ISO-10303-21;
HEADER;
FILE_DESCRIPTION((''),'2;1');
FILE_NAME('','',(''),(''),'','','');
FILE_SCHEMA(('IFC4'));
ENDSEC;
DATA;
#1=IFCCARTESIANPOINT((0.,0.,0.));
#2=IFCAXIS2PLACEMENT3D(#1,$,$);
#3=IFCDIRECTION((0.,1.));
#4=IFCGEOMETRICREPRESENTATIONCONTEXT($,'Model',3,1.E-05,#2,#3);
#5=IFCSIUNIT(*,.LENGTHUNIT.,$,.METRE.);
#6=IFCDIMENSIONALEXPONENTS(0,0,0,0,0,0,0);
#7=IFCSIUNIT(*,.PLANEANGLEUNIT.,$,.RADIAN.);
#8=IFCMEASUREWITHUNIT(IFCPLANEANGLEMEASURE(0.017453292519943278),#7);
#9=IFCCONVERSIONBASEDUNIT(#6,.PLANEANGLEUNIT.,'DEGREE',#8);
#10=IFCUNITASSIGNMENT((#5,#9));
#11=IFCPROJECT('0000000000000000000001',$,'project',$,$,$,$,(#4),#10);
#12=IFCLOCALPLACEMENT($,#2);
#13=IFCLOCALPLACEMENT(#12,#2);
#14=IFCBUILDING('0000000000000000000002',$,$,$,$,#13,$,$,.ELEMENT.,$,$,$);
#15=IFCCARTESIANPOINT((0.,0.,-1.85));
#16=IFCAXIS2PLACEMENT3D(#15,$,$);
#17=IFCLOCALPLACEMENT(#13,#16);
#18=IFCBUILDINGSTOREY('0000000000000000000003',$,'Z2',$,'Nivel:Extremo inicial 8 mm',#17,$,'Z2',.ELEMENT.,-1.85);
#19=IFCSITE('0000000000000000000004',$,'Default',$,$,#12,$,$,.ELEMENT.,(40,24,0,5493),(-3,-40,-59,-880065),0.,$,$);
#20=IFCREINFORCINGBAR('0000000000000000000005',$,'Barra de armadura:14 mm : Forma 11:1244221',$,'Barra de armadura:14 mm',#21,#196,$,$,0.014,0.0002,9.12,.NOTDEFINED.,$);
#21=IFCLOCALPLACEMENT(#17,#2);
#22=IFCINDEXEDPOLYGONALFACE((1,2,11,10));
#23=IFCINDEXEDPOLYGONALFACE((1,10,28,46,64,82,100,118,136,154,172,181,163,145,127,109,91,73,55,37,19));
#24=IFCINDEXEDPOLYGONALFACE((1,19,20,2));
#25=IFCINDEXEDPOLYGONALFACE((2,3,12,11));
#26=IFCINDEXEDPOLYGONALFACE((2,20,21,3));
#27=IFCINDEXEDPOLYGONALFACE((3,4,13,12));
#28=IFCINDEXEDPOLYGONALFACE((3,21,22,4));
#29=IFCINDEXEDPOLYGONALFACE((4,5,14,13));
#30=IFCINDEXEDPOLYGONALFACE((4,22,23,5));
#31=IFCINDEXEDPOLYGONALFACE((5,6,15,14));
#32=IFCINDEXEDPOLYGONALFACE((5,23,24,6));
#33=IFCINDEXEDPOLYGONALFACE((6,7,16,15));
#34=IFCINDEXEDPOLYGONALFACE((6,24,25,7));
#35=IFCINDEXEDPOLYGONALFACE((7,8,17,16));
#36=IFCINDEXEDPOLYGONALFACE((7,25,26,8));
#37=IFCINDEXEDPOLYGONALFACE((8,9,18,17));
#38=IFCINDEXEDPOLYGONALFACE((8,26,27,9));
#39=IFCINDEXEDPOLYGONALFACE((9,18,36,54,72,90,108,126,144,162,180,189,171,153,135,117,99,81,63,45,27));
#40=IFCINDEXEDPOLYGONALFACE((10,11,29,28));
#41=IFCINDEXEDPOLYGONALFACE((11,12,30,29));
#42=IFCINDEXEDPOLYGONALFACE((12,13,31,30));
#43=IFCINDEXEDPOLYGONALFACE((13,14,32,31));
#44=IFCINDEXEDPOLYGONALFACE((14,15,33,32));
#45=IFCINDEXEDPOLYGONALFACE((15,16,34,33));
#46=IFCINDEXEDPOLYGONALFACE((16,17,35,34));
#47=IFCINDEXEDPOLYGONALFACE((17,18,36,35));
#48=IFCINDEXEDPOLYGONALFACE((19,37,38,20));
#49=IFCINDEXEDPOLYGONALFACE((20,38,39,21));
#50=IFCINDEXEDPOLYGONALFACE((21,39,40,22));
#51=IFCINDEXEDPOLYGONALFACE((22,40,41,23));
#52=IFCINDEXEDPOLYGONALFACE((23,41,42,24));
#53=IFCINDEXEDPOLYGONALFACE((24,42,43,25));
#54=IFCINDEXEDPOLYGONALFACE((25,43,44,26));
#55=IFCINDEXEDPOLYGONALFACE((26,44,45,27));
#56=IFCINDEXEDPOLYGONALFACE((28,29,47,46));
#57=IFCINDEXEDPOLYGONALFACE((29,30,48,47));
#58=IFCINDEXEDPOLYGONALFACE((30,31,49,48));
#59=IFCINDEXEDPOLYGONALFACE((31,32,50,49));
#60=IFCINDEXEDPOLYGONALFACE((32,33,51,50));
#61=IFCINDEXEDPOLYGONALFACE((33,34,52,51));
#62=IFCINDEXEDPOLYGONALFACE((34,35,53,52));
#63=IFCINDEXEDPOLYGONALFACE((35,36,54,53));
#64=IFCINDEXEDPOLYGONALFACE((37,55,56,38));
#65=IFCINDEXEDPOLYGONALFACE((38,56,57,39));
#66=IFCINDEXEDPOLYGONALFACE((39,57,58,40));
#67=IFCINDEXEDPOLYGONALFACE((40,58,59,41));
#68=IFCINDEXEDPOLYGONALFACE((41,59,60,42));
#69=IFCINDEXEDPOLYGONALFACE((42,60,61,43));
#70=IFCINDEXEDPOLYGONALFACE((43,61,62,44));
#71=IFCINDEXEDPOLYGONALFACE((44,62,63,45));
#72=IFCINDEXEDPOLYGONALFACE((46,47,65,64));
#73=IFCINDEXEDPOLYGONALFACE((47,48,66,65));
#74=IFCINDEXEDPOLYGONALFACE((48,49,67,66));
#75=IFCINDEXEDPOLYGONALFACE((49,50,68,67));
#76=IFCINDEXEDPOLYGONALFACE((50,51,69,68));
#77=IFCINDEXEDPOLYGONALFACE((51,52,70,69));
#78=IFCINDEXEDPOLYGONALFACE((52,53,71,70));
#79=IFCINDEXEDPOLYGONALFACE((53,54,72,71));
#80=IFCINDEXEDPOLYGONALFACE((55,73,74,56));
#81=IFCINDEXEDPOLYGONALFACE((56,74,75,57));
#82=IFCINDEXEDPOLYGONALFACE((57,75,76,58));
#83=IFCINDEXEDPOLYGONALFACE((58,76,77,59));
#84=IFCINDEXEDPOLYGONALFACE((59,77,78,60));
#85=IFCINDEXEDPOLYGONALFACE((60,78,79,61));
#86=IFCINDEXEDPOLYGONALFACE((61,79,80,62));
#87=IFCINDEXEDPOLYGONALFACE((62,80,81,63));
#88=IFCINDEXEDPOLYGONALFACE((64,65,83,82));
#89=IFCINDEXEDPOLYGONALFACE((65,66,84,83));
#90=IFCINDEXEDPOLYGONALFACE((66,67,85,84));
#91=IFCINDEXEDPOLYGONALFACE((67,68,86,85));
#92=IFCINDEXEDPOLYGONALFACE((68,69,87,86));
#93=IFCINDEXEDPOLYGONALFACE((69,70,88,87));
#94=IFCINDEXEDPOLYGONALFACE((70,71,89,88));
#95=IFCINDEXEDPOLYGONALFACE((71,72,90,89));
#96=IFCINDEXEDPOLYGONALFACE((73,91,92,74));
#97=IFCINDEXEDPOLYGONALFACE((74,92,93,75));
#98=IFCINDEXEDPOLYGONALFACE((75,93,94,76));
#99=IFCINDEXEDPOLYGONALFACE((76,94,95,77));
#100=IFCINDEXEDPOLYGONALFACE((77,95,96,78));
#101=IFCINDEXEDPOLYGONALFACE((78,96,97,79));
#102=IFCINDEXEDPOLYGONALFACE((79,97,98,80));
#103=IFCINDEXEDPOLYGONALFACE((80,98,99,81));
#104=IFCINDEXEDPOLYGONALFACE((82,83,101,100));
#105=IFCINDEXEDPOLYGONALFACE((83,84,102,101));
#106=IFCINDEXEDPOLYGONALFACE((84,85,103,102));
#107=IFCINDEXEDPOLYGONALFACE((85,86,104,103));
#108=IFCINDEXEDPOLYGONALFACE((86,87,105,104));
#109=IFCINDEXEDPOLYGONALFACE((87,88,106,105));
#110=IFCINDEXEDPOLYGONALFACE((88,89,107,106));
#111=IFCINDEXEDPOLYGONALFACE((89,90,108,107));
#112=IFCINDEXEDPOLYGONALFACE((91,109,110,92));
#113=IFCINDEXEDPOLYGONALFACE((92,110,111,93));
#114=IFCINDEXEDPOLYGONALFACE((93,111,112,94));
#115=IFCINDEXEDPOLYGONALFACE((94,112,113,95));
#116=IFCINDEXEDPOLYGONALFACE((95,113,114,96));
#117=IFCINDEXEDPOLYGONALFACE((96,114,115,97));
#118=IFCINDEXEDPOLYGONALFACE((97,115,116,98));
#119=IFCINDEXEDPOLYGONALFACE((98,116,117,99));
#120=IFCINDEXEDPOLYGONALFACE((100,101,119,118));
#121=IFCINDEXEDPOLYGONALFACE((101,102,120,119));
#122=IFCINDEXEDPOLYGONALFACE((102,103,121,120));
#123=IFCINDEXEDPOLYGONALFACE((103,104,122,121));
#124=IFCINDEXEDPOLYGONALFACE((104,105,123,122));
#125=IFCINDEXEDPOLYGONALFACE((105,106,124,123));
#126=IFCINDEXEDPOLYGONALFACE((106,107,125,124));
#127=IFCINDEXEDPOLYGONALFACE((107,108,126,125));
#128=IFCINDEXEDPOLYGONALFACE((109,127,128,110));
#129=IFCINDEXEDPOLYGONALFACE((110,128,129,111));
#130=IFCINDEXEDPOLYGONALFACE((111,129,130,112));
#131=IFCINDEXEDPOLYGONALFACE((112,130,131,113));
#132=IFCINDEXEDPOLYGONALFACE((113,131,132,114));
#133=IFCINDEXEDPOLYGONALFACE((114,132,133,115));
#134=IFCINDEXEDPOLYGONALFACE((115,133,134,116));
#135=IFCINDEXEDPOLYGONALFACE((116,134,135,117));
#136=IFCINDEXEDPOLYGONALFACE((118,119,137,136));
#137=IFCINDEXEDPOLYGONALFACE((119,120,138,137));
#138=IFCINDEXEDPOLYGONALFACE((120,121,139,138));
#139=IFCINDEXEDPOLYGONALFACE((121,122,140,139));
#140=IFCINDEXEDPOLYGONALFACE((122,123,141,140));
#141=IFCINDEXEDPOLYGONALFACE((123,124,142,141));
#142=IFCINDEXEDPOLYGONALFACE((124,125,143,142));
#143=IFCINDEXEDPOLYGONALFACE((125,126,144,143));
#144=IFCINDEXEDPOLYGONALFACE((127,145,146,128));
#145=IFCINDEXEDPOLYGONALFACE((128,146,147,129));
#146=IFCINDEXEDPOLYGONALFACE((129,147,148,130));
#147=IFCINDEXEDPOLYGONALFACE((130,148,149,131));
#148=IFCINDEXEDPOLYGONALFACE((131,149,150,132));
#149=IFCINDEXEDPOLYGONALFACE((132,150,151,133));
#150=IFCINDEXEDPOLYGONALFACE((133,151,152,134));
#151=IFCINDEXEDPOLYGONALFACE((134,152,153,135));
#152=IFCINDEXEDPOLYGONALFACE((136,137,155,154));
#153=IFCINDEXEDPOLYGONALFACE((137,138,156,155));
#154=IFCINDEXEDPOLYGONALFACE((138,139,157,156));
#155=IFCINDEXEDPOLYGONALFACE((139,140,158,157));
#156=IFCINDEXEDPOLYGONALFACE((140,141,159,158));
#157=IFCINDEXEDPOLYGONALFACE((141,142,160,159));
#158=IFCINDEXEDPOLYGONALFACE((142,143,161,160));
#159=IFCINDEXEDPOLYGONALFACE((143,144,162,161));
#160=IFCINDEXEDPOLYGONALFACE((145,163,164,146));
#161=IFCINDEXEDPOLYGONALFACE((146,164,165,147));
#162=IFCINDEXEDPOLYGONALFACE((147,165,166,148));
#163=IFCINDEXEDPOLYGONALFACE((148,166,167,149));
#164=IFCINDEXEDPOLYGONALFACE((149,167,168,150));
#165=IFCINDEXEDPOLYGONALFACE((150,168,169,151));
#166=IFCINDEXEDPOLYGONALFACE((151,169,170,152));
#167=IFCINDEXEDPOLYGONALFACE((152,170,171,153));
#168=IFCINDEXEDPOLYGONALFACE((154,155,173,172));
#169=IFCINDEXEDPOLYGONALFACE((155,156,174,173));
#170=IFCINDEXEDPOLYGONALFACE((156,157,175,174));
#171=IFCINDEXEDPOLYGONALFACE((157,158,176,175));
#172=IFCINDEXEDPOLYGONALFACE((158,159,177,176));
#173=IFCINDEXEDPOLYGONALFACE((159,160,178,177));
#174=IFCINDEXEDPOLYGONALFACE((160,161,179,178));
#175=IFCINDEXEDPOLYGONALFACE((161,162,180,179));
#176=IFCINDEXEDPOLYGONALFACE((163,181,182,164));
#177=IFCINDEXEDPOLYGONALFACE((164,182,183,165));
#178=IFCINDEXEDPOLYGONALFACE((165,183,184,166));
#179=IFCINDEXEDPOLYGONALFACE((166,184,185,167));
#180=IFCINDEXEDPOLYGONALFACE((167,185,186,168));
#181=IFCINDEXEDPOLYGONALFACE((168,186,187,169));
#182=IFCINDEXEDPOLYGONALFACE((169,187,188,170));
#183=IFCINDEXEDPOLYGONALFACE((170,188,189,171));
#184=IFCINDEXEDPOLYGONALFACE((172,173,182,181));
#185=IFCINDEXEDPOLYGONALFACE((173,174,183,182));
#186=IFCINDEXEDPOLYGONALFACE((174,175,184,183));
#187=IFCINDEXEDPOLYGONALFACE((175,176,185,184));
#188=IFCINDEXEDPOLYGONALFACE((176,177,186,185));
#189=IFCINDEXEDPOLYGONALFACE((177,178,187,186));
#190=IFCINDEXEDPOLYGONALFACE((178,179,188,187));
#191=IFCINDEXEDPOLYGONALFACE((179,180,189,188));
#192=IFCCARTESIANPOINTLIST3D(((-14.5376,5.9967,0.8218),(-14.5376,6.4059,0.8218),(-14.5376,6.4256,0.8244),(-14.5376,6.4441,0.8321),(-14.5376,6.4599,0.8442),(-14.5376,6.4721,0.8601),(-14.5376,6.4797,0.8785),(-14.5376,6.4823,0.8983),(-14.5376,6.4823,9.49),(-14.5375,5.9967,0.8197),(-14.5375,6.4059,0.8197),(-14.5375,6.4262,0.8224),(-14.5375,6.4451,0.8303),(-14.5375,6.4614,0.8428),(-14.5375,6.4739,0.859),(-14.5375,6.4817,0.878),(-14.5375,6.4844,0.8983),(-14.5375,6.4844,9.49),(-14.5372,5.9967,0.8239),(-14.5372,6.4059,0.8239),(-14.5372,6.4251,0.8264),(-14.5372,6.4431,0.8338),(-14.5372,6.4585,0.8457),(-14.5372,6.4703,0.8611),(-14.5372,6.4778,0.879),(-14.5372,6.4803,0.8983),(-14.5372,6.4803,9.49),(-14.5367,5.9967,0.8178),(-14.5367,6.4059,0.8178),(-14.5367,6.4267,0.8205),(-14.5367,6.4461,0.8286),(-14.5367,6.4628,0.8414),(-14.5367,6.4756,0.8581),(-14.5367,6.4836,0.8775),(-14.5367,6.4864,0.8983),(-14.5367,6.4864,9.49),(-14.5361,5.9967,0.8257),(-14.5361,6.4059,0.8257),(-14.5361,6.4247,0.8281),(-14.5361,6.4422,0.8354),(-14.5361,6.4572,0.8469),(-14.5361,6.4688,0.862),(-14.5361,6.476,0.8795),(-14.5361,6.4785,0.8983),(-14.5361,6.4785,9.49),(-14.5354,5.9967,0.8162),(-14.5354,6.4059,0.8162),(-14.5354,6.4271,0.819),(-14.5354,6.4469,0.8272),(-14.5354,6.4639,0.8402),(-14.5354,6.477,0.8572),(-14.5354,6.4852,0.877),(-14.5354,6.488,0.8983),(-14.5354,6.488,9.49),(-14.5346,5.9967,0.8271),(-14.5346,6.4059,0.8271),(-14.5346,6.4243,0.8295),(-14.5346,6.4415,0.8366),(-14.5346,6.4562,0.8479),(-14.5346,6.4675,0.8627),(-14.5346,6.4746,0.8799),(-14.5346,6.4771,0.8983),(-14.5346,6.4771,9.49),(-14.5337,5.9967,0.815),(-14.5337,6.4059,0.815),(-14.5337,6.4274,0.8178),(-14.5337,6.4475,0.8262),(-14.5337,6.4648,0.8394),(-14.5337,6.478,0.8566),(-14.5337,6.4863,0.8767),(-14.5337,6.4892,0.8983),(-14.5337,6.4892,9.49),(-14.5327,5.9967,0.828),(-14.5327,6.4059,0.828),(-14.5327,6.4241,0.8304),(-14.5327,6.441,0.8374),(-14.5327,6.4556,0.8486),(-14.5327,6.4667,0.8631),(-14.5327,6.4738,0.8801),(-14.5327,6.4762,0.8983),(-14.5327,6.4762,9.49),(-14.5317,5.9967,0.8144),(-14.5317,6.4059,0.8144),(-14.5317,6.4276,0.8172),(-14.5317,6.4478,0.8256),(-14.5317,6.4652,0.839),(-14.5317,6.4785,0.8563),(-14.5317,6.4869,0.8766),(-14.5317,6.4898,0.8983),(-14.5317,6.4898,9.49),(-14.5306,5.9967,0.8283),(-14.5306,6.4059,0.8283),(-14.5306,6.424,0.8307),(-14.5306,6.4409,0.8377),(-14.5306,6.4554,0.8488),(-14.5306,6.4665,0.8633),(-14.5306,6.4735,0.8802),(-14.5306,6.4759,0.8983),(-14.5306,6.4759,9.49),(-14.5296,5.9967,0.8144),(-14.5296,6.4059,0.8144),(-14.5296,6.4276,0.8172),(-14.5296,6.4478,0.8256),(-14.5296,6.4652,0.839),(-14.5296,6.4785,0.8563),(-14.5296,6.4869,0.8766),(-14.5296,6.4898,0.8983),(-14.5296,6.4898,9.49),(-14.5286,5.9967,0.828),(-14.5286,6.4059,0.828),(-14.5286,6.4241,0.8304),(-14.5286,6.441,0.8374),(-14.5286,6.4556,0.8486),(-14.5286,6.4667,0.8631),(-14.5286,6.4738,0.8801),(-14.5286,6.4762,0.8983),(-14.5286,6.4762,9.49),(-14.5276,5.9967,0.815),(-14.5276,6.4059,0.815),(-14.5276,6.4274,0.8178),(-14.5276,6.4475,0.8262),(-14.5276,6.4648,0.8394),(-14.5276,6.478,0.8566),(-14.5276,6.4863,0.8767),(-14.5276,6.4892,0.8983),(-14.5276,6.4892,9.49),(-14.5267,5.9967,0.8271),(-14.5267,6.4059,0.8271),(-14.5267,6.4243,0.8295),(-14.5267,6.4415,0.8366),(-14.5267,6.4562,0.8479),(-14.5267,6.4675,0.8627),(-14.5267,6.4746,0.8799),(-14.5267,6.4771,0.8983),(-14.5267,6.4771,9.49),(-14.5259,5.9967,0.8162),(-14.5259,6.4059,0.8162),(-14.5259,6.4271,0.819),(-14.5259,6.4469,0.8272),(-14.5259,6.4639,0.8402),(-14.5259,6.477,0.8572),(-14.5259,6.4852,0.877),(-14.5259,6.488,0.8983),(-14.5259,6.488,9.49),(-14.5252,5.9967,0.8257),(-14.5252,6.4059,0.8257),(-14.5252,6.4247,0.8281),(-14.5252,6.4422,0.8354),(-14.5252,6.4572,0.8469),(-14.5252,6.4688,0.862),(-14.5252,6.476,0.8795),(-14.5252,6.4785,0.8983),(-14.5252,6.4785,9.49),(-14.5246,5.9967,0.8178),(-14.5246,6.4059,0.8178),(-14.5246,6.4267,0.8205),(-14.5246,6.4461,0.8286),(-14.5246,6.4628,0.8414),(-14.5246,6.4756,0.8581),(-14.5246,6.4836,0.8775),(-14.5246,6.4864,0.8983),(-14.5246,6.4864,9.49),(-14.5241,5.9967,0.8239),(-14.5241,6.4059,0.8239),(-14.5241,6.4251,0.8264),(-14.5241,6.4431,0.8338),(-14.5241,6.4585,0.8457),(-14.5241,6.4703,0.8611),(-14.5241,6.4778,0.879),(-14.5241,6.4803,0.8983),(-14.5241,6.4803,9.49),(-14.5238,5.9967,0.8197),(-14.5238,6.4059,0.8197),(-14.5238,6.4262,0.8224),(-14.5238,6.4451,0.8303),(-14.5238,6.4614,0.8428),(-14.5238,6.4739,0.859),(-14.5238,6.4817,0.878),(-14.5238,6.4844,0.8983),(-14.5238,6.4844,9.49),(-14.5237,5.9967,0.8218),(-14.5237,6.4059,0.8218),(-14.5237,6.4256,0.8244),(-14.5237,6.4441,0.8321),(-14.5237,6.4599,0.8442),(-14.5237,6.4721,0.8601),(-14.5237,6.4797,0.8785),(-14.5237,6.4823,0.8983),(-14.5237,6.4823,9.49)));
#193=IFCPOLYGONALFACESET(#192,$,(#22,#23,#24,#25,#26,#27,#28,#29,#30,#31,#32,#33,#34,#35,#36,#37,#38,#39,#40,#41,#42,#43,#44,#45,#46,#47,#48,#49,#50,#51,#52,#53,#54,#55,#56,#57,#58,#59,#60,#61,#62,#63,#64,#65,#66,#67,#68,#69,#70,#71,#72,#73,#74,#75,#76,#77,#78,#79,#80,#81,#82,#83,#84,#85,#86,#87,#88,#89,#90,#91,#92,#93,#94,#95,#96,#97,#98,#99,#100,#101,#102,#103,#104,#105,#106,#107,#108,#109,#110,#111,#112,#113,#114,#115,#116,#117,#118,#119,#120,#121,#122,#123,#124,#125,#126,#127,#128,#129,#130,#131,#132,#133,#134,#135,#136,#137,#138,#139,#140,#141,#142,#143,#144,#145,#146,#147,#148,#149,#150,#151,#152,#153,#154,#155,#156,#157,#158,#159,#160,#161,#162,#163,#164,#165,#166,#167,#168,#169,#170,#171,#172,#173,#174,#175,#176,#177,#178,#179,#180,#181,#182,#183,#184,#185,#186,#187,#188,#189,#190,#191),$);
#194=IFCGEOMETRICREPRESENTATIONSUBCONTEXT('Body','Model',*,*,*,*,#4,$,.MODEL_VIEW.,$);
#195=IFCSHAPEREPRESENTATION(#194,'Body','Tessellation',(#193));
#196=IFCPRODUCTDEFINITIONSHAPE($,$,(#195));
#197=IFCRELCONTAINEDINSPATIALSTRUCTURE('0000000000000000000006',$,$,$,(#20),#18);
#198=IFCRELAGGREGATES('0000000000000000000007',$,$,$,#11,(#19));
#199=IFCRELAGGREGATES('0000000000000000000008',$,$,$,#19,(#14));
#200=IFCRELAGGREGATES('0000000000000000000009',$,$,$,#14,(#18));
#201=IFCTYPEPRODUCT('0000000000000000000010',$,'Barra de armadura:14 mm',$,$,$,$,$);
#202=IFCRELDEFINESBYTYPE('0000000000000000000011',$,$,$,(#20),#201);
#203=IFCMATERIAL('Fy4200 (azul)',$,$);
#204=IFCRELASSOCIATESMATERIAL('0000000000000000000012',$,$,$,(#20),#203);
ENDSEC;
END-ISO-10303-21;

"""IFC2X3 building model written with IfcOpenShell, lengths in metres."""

from ifc_helpers import new_model, entity, si_unit, converted_unit, direction, frame, origin, place, context, subcontext, project, spatial, material, type_object, element, save


model = new_model("IFC2X3")

# Units and contexts
model_context = context("Model", 3, precision=1e-05, world=origin(), true_north=direction((0.0, 1.0)))
body_context = subcontext(model_context, "Body", "Model", "MODEL_VIEW")
ifc_project = project(units=[si_unit("LENGTHUNIT", "METRE"), converted_unit("PLANEANGLEUNIT", "DEGREE", entity("IfcPlaneAngleMeasure", 0.017453292519943278), si_unit("PLANEANGLEUNIT", "RADIAN"), dimensions=[0, 0, 0, 0, 0, 0, 0])], contexts=[model_context])

# Site, building, storey
site_placement = place(None, origin())
site = spatial("IfcSite", under=ifc_project, at=site_placement, Name="Default", CompositionType="ELEMENT", RefLatitude=(40, 24, 0, 5493), RefLongitude=(-3, -40, -59, -880065), RefElevation=0.0)
building_placement = place(site_placement, origin())
building = spatial("IfcBuilding", under=site, at=building_placement, CompositionType="ELEMENT")
storey_placement = place(building_placement, frame((0.0, 0.0, -1.85)))
storey = spatial("IfcBuildingStorey", under=building, at=storey_placement, Name="Z2", ObjectType="Nivel:Extremo inicial 8 mm", LongName="Z2", CompositionType="ELEMENT", Elevation=-1.85)

# Reinforcing bar
ifc_material_1 = material(Name="Fy4200 (azul)")
type_product_1 = type_object("IfcTypeProduct", Name="Barra de armadura:14 mm")
reinforcing_bar_1_placement = place(storey_placement, origin())
element("IfcReinforcingBar", 1, at=reinforcing_bar_1_placement, inside=storey, type_object=type_product_1, material=ifc_material_1, Name="Barra de armadura:14 mm : Forma 11:1244221", ObjectType="Barra de armadura:14 mm", BarLength=9.12, BarRole="NOTDEFINED", CrossSectionArea=0.0002, NominalDiameter=0.014, context=body_context, shape_type="AdvancedSweptSolid", body=[
    entity("IfcSweptDiskSolid", entity("IfcCompositeCurve", [entity("IfcCompositeCurveSegment", "CONTINUOUS", True, entity("IfcPolyline", [entity("IfcCartesianPoint", [-14.5306, 6.4829, 9.49]), entity("IfcCartesianPoint", [-14.5306, 6.4829, 0.8983])])), entity("IfcCompositeCurveSegment", "CONTINUOUS", True, entity("IfcTrimmedCurve", entity("IfcCircle", entity("IfcAxis2Placement3D", entity("IfcCartesianPoint", [-14.5306, 6.4059, 0.8983]), entity("IfcDirection", [-1.0, 0.0, 0.0]), entity("IfcDirection", [0.0, 0.0, -1.0])), 0.077), [entity("IfcParameterValue", 270.0)], [entity("IfcParameterValue", 360.0)], True, "PARAMETER")), entity("IfcCompositeCurveSegment", "CONTINUOUS", True, entity("IfcPolyline", [entity("IfcCartesianPoint", [-14.5306, 6.4059, 0.8213]), entity("IfcCartesianPoint", [-14.5306, 5.9967, 0.8213])]))], False), 0.007, None, 0.0, 92.0),
])

save(model, "model.ifc")
